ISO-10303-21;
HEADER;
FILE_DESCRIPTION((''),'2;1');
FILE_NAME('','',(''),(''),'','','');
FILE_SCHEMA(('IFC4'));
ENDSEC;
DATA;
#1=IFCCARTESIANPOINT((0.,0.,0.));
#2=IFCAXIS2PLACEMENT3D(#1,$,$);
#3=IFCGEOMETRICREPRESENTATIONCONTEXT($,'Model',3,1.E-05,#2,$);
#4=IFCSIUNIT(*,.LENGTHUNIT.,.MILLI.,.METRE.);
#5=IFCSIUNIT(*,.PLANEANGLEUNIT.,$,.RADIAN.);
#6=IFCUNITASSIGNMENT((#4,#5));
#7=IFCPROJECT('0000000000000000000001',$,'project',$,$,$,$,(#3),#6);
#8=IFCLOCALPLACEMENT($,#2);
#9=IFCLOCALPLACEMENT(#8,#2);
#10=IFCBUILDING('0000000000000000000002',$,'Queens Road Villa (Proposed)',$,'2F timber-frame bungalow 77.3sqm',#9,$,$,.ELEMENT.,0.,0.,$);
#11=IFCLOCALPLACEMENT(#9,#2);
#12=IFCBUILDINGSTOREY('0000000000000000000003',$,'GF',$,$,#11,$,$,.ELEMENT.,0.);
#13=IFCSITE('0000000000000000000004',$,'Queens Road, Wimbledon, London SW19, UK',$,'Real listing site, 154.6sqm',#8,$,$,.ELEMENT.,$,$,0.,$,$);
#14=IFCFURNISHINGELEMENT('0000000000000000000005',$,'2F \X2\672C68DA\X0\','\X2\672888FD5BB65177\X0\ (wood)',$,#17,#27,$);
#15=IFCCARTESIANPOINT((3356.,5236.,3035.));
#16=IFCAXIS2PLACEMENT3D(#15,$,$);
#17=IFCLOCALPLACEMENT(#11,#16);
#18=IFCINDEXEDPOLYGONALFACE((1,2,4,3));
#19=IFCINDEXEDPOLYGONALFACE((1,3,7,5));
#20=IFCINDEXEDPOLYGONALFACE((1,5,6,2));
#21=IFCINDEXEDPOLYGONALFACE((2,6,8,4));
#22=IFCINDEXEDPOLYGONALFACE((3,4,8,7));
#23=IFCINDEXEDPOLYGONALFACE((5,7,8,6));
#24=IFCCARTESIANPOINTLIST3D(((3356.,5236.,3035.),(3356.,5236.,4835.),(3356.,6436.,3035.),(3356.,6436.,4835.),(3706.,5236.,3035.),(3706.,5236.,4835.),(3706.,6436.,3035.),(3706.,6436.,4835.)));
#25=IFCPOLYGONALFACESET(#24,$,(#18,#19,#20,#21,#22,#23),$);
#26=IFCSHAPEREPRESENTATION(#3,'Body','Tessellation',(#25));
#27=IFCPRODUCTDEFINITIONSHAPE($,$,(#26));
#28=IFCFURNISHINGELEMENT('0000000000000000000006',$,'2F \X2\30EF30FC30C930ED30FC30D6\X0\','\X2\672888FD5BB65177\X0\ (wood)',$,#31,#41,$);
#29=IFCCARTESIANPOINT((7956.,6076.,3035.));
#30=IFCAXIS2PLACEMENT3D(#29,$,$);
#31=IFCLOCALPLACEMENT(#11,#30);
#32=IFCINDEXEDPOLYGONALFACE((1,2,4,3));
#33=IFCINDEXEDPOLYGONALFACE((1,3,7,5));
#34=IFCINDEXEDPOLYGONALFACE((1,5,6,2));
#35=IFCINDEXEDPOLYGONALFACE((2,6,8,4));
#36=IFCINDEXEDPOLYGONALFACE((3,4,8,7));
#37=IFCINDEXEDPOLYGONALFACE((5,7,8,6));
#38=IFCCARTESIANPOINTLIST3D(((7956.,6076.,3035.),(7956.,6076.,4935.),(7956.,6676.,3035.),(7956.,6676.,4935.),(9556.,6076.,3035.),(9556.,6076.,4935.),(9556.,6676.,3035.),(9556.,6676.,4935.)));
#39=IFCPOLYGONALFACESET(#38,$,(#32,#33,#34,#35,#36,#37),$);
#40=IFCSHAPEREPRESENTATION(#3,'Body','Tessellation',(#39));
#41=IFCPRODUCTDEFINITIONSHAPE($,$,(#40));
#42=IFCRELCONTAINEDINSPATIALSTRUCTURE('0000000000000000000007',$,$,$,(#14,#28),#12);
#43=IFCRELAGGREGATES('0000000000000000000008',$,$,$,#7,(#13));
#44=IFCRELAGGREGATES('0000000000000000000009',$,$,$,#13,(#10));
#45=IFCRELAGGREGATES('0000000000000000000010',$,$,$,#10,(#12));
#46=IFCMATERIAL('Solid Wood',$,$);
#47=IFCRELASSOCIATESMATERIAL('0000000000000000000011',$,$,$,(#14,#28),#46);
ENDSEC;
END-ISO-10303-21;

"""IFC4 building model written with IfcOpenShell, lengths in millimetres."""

from ifc_helpers import new_model, si_unit, frame, frame_2d, origin, place, context, project, spatial, rectangle, extrude, material, element, save


model = new_model("IFC4")

# Units and contexts
model_context = context("Model", 3, precision=1e-05, world=origin())
ifc_project = project(units=[si_unit("LENGTHUNIT", "METRE", prefix="MILLI"), si_unit("PLANEANGLEUNIT", "RADIAN")], contexts=[model_context])

# Site, building, storey
site_placement = place(None, origin())
site = spatial("IfcSite", under=ifc_project, at=site_placement, Name="Queens Road, Wimbledon, London SW19, UK", ObjectType="Real listing site, 154.6sqm", CompositionType="ELEMENT", RefElevation=0.0)
building_placement = place(site_placement, origin())
building = spatial("IfcBuilding", under=site, at=building_placement, Name="Queens Road Villa (Proposed)", ObjectType="2F timber-frame bungalow 77.3sqm", CompositionType="ELEMENT", ElevationOfRefHeight=0.0, ElevationOfTerrain=0.0)
storey_placement = place(building_placement, origin())
storey = spatial("IfcBuildingStorey", under=building, at=storey_placement, Name="GF", CompositionType="ELEMENT", Elevation=0.0)

# Shared definitions
ifc_material_1 = material(Name="Solid Wood")

# Furnishing elements
furnishing_1_placement = place(storey_placement, frame((3356.0, 5236.0, 3035.0)))
element("IfcFurnishingElement", 1, at=furnishing_1_placement, inside=storey, material=ifc_material_1, Name="2F 本棚", Description="木製家具 (wood)", context=model_context, shape_type="SweptSolid", body=[
    extrude(rectangle(XDim=350.0, YDim=1200.0, at=frame_2d((175.0, 600.0))), frame((3356.0, 5236.0, 3035.0)), (0.0, 0.0, 1.0), 1800.0),
])
furnishing_2_placement = place(storey_placement, frame((7956.0, 6076.0, 3035.0)))
element("IfcFurnishingElement", 2, at=furnishing_2_placement, inside=storey, material=ifc_material_1, Name="2F ワードローブ", Description="木製家具 (wood)", context=model_context, shape_type="SweptSolid", body=[
    extrude(rectangle(XDim=1600.0, YDim=600.0, at=frame_2d((800.0, 300.0))), frame((7956.0, 6076.0, 3035.0)), (0.0, 0.0, 1.0), 1900.0),
])

save(model, "model.ifc")
